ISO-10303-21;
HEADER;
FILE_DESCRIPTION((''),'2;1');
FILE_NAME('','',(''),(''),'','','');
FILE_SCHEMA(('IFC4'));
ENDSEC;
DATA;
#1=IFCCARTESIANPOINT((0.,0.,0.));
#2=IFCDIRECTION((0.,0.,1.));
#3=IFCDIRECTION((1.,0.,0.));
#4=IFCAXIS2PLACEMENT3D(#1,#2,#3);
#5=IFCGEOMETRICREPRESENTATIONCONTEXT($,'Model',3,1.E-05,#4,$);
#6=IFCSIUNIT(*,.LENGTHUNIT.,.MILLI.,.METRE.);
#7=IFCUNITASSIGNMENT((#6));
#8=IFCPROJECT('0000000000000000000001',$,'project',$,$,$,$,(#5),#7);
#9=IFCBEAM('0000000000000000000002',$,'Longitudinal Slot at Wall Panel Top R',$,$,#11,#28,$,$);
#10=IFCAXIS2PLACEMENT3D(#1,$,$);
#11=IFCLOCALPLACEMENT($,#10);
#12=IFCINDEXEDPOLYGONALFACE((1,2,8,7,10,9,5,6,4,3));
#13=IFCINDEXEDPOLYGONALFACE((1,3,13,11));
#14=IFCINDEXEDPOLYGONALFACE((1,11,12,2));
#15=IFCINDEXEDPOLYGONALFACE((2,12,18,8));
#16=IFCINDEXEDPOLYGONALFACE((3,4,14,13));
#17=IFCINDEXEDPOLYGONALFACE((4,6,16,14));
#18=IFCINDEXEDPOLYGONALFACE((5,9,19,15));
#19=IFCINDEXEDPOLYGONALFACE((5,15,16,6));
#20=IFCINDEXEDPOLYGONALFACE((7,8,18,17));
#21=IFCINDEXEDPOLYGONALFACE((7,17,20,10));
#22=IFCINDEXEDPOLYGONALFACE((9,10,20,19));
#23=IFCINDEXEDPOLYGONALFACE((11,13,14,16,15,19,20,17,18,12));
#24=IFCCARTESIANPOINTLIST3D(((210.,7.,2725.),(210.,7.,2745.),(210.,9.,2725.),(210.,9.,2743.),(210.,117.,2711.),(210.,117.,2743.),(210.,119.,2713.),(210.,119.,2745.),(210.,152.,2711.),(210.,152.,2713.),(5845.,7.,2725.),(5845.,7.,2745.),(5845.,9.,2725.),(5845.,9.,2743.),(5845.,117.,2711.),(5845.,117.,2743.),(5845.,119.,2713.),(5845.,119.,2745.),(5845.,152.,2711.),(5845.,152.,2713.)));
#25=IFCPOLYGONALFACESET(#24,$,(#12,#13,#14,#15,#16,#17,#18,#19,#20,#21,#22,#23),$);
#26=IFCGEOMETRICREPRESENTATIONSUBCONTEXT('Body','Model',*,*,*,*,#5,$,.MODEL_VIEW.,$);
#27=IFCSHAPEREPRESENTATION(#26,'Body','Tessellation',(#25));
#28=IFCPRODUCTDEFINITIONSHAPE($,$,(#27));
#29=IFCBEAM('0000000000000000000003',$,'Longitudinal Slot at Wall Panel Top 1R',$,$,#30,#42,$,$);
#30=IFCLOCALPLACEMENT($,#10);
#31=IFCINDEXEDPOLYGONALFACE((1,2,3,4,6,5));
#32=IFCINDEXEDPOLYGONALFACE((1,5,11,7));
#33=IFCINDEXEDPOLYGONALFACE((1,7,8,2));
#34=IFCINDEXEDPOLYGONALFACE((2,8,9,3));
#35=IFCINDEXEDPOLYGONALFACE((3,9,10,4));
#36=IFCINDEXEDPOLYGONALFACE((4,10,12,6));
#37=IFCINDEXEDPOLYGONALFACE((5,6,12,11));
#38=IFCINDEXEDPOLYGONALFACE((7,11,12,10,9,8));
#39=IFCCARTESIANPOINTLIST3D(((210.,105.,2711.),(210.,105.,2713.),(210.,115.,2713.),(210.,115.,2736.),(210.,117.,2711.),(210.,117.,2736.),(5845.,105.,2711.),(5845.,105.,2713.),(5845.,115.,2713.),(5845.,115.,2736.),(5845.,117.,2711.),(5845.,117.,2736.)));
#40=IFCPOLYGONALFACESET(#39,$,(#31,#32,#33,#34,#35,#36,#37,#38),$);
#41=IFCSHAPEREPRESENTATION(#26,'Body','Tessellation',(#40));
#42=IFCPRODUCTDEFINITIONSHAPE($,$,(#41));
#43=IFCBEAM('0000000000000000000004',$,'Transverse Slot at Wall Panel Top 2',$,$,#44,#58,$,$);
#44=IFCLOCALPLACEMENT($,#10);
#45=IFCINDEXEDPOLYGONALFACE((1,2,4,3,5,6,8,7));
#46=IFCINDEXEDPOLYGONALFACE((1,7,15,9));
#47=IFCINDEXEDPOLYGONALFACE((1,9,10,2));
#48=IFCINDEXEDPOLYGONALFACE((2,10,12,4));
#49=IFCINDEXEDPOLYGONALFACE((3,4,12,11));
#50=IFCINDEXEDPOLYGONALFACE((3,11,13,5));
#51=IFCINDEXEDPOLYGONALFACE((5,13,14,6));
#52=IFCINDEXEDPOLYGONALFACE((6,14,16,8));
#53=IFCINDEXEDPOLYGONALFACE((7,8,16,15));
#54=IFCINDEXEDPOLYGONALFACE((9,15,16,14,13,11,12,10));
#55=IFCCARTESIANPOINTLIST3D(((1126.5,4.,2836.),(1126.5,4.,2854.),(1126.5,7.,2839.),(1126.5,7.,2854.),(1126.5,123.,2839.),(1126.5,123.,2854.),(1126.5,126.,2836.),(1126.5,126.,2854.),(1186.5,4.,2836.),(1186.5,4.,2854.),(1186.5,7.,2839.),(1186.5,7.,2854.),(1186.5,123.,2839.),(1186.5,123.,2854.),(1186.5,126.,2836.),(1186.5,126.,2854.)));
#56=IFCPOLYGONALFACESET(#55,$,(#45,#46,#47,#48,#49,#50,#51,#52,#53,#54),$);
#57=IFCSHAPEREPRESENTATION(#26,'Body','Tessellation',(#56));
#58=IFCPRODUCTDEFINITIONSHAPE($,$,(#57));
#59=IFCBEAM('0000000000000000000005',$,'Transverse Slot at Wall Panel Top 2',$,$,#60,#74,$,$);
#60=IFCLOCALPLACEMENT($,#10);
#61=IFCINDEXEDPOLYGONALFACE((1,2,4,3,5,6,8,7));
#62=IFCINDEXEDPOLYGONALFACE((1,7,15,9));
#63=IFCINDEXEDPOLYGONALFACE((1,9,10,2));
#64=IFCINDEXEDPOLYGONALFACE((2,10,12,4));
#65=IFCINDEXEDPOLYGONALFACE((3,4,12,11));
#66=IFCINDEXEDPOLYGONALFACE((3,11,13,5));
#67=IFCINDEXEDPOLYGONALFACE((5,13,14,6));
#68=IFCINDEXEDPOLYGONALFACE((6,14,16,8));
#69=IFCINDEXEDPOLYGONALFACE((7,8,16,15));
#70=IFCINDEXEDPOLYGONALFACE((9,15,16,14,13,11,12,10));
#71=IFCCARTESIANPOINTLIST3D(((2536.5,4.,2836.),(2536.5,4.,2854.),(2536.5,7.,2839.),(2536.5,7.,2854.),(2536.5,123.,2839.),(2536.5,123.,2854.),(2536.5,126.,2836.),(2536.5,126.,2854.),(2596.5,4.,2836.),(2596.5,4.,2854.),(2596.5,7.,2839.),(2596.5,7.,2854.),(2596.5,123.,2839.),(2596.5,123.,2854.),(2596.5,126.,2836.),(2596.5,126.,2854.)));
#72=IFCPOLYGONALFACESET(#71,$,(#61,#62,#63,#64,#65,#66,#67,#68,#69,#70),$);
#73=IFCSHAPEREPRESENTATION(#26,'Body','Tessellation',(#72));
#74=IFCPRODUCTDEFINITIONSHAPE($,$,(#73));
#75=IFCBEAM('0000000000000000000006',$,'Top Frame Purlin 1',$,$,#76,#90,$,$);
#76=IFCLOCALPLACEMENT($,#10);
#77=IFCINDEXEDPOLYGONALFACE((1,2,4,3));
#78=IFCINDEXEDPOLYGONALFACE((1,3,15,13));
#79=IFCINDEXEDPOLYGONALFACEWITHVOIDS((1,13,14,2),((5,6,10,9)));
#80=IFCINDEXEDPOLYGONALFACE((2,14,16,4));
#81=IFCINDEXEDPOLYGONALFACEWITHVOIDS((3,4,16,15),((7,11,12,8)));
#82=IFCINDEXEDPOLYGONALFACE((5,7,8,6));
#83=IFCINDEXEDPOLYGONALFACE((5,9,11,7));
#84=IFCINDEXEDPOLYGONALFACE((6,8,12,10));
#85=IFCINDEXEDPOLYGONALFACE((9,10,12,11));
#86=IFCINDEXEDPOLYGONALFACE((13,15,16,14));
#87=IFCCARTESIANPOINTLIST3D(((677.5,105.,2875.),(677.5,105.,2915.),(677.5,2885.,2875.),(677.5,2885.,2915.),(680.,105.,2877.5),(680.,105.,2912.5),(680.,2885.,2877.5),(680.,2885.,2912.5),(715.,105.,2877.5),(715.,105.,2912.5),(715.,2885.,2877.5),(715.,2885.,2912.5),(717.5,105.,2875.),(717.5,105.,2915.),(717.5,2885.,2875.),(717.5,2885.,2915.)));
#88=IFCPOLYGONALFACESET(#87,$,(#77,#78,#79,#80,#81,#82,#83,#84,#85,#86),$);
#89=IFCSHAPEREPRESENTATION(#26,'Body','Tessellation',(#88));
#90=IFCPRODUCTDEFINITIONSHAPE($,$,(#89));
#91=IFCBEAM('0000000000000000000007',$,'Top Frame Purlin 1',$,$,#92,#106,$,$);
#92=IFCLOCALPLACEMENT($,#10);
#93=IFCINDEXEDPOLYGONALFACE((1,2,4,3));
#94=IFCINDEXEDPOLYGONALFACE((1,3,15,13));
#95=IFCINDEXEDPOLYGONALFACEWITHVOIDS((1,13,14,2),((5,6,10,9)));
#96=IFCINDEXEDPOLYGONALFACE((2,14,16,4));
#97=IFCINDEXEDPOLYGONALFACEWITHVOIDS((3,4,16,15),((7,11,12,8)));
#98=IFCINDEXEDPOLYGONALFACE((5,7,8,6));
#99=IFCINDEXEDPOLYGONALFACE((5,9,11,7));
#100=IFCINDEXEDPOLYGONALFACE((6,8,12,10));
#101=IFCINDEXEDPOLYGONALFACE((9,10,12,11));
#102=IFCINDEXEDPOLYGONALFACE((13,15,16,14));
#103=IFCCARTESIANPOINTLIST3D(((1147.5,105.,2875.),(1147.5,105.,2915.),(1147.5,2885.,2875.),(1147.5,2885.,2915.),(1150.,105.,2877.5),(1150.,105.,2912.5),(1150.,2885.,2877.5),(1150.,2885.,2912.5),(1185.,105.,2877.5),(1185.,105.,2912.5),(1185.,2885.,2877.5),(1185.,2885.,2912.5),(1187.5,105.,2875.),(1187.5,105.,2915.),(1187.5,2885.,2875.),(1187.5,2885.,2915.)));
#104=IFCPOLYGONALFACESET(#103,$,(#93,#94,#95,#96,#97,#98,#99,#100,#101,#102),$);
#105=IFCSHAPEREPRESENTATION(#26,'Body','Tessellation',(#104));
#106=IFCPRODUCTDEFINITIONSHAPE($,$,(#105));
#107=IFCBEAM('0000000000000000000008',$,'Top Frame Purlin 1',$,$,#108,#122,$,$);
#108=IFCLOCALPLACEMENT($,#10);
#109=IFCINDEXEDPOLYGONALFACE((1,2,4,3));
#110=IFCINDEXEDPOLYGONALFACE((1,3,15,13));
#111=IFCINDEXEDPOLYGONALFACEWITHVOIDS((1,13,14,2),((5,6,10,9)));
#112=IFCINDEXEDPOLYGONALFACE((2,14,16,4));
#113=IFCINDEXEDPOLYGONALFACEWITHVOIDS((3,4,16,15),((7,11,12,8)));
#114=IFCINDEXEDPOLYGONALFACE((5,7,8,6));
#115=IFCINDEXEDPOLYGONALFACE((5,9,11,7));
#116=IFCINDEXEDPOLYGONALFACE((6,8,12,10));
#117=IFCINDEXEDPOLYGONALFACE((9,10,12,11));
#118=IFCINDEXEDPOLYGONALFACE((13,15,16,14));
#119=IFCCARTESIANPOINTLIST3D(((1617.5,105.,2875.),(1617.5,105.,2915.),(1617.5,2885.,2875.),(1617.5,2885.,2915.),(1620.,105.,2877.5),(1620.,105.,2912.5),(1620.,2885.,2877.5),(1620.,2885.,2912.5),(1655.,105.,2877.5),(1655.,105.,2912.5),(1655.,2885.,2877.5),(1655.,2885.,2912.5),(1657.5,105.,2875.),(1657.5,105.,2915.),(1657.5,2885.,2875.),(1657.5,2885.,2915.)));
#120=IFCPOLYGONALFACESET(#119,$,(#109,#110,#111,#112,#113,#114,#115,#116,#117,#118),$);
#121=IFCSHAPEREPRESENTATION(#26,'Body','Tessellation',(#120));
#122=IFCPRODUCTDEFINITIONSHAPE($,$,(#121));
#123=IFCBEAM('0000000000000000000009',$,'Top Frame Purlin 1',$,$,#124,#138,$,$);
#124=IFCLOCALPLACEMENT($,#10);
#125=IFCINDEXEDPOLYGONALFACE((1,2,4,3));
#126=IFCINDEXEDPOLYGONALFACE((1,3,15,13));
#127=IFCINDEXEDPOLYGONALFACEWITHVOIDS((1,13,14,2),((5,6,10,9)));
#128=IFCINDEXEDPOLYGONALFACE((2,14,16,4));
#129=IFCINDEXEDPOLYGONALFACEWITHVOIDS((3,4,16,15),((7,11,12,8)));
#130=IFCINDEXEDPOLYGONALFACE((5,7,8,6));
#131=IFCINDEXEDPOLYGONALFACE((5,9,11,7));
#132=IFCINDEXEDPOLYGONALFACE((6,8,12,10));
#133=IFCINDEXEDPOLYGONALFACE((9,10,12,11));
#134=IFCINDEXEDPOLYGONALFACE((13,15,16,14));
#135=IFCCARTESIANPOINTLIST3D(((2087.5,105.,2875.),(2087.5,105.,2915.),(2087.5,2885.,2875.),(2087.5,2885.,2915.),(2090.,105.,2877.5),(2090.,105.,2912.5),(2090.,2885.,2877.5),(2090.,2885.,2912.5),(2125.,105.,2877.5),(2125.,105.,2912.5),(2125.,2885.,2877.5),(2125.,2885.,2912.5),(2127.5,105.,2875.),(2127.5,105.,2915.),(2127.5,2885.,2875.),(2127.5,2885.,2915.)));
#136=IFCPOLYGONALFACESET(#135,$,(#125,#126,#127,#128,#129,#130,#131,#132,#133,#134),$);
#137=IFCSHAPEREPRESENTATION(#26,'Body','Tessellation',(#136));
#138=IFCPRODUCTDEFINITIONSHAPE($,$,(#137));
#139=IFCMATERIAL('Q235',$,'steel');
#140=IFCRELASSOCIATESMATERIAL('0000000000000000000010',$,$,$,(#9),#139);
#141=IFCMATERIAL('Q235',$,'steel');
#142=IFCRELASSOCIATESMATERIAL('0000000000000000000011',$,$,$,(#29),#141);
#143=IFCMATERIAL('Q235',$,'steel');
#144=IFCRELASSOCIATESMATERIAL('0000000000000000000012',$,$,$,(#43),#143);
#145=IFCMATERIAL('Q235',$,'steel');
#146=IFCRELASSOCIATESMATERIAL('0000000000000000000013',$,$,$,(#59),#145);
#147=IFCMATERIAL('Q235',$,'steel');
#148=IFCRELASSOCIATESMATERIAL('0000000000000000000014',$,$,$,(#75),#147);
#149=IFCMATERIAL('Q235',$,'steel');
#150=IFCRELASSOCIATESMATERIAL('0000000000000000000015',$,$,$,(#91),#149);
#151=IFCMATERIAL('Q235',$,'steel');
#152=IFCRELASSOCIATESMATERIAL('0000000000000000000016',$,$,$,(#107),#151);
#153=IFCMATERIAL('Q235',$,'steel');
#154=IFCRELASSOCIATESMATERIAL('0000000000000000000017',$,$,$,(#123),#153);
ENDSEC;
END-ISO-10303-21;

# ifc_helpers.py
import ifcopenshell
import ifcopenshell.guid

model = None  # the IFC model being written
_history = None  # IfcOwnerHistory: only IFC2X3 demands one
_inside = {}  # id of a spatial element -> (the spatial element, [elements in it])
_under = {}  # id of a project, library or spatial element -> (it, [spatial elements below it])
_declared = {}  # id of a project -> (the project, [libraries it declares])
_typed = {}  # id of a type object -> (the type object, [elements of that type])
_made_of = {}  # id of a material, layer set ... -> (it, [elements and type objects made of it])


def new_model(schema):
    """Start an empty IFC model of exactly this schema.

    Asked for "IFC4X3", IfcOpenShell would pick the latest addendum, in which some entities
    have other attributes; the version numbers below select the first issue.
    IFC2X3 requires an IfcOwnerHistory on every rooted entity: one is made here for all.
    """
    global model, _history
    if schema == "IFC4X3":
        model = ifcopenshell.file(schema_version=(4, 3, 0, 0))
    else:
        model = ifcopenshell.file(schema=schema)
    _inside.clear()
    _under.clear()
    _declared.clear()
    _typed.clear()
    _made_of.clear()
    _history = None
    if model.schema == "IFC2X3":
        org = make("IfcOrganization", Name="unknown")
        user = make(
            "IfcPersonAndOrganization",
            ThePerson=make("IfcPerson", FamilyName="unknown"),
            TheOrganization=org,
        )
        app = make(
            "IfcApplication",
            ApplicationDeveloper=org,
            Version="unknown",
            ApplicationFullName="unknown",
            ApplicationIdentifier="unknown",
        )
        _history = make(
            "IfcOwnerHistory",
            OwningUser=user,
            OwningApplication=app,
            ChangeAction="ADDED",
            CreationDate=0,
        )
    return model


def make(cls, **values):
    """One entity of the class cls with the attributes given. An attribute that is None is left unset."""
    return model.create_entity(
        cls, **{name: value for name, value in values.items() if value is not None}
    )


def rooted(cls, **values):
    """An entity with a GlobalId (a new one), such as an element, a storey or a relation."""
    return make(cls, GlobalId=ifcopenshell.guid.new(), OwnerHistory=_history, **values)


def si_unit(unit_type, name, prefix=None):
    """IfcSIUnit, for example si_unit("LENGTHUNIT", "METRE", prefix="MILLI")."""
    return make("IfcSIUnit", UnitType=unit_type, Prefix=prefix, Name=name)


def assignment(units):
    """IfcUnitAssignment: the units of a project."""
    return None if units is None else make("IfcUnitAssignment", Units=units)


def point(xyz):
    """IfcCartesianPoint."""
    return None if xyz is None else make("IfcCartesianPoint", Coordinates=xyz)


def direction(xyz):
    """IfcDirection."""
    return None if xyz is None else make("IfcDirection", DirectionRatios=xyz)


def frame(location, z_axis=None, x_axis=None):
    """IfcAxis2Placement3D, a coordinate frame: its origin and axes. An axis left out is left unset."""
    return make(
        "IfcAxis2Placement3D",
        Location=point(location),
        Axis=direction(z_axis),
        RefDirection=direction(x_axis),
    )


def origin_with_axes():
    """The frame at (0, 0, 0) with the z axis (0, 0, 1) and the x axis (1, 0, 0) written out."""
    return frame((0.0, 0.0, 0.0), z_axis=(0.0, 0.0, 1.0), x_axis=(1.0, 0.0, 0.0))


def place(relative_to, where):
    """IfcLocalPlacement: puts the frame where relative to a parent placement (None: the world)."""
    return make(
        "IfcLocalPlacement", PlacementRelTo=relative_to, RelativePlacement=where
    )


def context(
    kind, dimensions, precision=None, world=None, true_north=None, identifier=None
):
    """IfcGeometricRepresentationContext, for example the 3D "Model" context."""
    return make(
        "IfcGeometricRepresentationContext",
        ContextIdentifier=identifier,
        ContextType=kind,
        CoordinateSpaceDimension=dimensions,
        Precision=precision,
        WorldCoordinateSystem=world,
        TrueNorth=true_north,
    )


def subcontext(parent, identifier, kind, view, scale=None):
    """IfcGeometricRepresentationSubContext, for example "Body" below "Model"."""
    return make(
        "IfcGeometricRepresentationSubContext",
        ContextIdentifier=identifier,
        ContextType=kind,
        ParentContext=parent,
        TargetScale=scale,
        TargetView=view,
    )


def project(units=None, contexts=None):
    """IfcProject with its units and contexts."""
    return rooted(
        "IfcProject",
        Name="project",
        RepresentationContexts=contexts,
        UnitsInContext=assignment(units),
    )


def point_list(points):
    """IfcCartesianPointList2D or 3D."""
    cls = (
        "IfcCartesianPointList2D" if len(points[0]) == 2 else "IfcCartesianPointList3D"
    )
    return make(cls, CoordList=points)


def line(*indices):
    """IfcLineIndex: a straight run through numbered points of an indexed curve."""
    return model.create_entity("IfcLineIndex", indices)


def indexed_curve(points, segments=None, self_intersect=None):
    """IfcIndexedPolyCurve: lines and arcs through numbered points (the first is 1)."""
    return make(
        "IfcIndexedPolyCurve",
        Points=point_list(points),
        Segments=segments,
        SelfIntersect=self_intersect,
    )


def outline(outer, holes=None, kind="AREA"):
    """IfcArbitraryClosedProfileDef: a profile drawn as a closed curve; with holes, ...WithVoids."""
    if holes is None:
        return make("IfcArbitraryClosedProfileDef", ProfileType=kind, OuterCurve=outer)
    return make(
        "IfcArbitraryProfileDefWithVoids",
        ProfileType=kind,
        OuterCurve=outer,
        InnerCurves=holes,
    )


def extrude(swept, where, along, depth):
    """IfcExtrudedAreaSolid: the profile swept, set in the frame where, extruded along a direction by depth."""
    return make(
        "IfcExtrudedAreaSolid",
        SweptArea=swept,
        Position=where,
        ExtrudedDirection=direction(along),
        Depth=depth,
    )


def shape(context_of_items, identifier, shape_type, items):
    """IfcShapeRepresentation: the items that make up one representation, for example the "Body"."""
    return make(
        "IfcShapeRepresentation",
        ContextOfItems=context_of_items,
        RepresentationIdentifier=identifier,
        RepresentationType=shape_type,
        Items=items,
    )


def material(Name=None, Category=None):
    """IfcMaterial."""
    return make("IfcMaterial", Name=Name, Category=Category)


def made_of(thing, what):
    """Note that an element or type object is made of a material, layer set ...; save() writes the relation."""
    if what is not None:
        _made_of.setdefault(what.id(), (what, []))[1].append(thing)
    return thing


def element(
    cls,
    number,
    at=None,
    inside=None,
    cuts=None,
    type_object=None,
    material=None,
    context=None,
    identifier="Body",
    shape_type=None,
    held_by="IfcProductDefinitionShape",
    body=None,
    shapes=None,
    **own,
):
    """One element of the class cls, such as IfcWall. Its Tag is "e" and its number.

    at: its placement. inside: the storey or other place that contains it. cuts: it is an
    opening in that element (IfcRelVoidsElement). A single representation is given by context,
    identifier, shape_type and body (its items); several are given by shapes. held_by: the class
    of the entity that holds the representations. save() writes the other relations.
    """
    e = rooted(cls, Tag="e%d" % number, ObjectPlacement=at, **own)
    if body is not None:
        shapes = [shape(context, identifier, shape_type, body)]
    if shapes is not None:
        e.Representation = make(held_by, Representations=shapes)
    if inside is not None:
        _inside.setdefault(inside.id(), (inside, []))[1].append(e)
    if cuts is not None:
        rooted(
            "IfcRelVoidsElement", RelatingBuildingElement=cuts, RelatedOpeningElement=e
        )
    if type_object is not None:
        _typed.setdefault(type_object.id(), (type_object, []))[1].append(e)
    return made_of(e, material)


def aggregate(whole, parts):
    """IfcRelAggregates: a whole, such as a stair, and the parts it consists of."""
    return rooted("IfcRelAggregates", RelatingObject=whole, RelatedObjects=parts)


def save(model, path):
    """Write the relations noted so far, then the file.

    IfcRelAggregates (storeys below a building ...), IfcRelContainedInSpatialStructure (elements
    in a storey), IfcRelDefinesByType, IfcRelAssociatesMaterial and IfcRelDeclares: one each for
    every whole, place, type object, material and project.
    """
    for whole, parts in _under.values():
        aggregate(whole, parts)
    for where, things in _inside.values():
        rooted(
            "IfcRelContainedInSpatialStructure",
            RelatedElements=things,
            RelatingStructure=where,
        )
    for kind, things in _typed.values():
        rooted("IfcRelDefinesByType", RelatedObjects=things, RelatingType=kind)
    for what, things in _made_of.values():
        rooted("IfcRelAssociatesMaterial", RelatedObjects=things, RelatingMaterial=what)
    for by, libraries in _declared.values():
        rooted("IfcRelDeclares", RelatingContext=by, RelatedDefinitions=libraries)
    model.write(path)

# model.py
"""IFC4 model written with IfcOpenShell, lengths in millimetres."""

from ifc_helpers import new_model, si_unit, frame, origin_with_axes, place, context, subcontext, project, line, indexed_curve, outline, extrude, material, element, save


model = new_model("IFC4")

# Units and contexts
model_context = context("Model", 3, precision=1e-05, world=origin_with_axes())
body_context = subcontext(model_context, "Body", "Model", "MODEL_VIEW")
ifc_project = project(units=[si_unit("LENGTHUNIT", "METRE", prefix="MILLI")], contexts=[model_context])

# Beams
ifc_material_1 = material(Name="Q235", Category="steel")
beam_1_placement = place(None, frame((210.0, 0.0, 2711.0), z_axis=(1.0, 0.0, 0.0), x_axis=(0.0, 1.0, 0.0)))
element("IfcBeam", 1, at=beam_1_placement, material=ifc_material_1, Name="Longitudinal Slot at Wall Panel Top R", context=body_context, shape_type="SweptSolid", body=[
    extrude(outline(indexed_curve([(152.0, 0.0), (117.0, 0.0), (117.0, 32.0), (9.0, 32.0), (9.0, 14.0), (7.0, 14.0), (7.0, 34.0), (119.0, 34.0), (119.0, 2.0), (152.0, 2.0), (152.0, 0.0)], segments=[line(1, 2, 3, 4, 5, 6, 7, 8, 9, 10, 11, 1)])), origin_with_axes(), (0.0, 0.0, 1.0), 5635.0),
])
ifc_material_2 = material(Name="Q235", Category="steel")
beam_2_placement = place(None, frame((210.0, 0.0, 2711.0), z_axis=(1.0, 0.0, 0.0), x_axis=(0.0, 1.0, 0.0)))
element("IfcBeam", 2, at=beam_2_placement, material=ifc_material_2, Name="Longitudinal Slot at Wall Panel Top 1R", context=body_context, shape_type="SweptSolid", body=[
    extrude(outline(indexed_curve([(117.0, 0.0), (105.0, 0.0), (105.0, 2.0), (115.0, 2.0), (115.0, 25.0), (117.0, 25.0), (117.0, 0.0)], segments=[line(1, 2, 3, 4, 5, 6, 7, 1)])), origin_with_axes(), (0.0, 0.0, 1.0), 5635.0),
])
ifc_material_3 = material(Name="Q235", Category="steel")
beam_3_placement = place(None, frame((1126.5, 4.0, 2836.0), z_axis=(1.0, 0.0, 0.0), x_axis=(0.0, 0.0, -1.0)))
element("IfcBeam", 3, at=beam_3_placement, material=ifc_material_3, Name="Transverse Slot at Wall Panel Top 2", context=body_context, shape_type="SweptSolid", body=[
    extrude(outline(indexed_curve([(0.0, 0.0), (0.0, 122.0), (-18.0, 122.0), (-18.0, 119.0), (-3.0, 119.0), (-3.0, 3.0), (-18.0, 3.0), (-18.0, 0.0), (0.0, 0.0)], segments=[line(1, 2, 3, 4, 5, 6, 7, 8, 9, 1)])), origin_with_axes(), (0.0, 0.0, 1.0), 60.0),
])
ifc_material_4 = material(Name="Q235", Category="steel")
beam_4_placement = place(None, frame((2536.5, 4.0, 2836.0), z_axis=(1.0, 0.0, 0.0), x_axis=(0.0, 0.0, -1.0)))
element("IfcBeam", 4, at=beam_4_placement, material=ifc_material_4, Name="Transverse Slot at Wall Panel Top 2", context=body_context, shape_type="SweptSolid", body=[
    extrude(outline(indexed_curve([(0.0, 0.0), (0.0, 122.0), (-18.0, 122.0), (-18.0, 119.0), (-3.0, 119.0), (-3.0, 3.0), (-18.0, 3.0), (-18.0, 0.0), (0.0, 0.0)], segments=[line(1, 2, 3, 4, 5, 6, 7, 8, 9, 1)])), origin_with_axes(), (0.0, 0.0, 1.0), 60.0),
])

# Beams, openings
ifc_material_5 = material(Name="Q235", Category="steel")
beam_5_placement = place(None, frame((677.5, 105.0, 2875.0), z_axis=(0.0, 1.0, 0.0), x_axis=(1.0, 0.0, 0.0)))
beam_5 = element("IfcBeam", 5, at=beam_5_placement, material=ifc_material_5, Name="Top Frame Purlin 1", context=body_context, shape_type="SweptSolid", body=[
    extrude(outline(indexed_curve([(0.0, 0.0), (0.0, -40.0), (40.0, -40.0), (40.0, 0.0), (0.0, 0.0)], segments=[line(1, 2, 3, 4, 5, 1)])), origin_with_axes(), (0.0, 0.0, 1.0), 2780.0),
])
opening_1_placement = place(beam_5_placement, frame((2.5, -2.5, 0.0), z_axis=(0.0, 0.0, 1.0), x_axis=(1.0, 0.0, 0.0)))
element("IfcOpeningElement", 6, at=opening_1_placement, cuts=beam_5, context=body_context, shape_type="SweptSolid", body=[
    extrude(outline(indexed_curve([(0.0, 0.0), (0.0, -35.0), (35.0, -35.0), (35.0, 0.0)], segments=[line(1, 2, 3, 4, 1)])), origin_with_axes(), (0.0, 0.0, 1.0), 2780.0),
])
ifc_material_6 = material(Name="Q235", Category="steel")
beam_6_placement = place(None, frame((1147.5, 105.0, 2875.0), z_axis=(0.0, 1.0, 0.0), x_axis=(1.0, 0.0, 0.0)))
beam_6 = element("IfcBeam", 7, at=beam_6_placement, material=ifc_material_6, Name="Top Frame Purlin 1", context=body_context, shape_type="SweptSolid", body=[
    extrude(outline(indexed_curve([(0.0, 0.0), (0.0, -40.0), (40.0, -40.0), (40.0, 0.0), (0.0, 0.0)], segments=[line(1, 2, 3, 4, 5, 1)])), origin_with_axes(), (0.0, 0.0, 1.0), 2780.0),
])
opening_2_placement = place(beam_6_placement, frame((2.5, -2.5, 0.0), z_axis=(0.0, 0.0, 1.0), x_axis=(1.0, 0.0, 0.0)))
element("IfcOpeningElement", 8, at=opening_2_placement, cuts=beam_6, context=body_context, shape_type="SweptSolid", body=[
    extrude(outline(indexed_curve([(0.0, 0.0), (0.0, -35.0), (35.0, -35.0), (35.0, 0.0)], segments=[line(1, 2, 3, 4, 1)])), origin_with_axes(), (0.0, 0.0, 1.0), 2780.0),
])
ifc_material_7 = material(Name="Q235", Category="steel")
beam_7_placement = place(None, frame((1617.5, 105.0, 2875.0), z_axis=(0.0, 1.0, 0.0), x_axis=(1.0, 0.0, 0.0)))
beam_7 = element("IfcBeam", 9, at=beam_7_placement, material=ifc_material_7, Name="Top Frame Purlin 1", context=body_context, shape_type="SweptSolid", body=[
    extrude(outline(indexed_curve([(0.0, 0.0), (0.0, -40.0), (40.0, -40.0), (40.0, 0.0), (0.0, 0.0)], segments=[line(1, 2, 3, 4, 5, 1)])), origin_with_axes(), (0.0, 0.0, 1.0), 2780.0),
])
opening_3_placement = place(beam_7_placement, frame((2.5, -2.5, 0.0), z_axis=(0.0, 0.0, 1.0), x_axis=(1.0, 0.0, 0.0)))
element("IfcOpeningElement", 10, at=opening_3_placement, cuts=beam_7, context=body_context, shape_type="SweptSolid", body=[
    extrude(outline(indexed_curve([(0.0, 0.0), (0.0, -35.0), (35.0, -35.0), (35.0, 0.0)], segments=[line(1, 2, 3, 4, 1)])), origin_with_axes(), (0.0, 0.0, 1.0), 2780.0),
])
ifc_material_8 = material(Name="Q235", Category="steel")
beam_8_placement = place(None, frame((2087.5, 105.0, 2875.0), z_axis=(0.0, 1.0, 0.0), x_axis=(1.0, 0.0, 0.0)))
beam_8 = element("IfcBeam", 11, at=beam_8_placement, material=ifc_material_8, Name="Top Frame Purlin 1", context=body_context, shape_type="SweptSolid", body=[
    extrude(outline(indexed_curve([(0.0, 0.0), (0.0, -40.0), (40.0, -40.0), (40.0, 0.0), (0.0, 0.0)], segments=[line(1, 2, 3, 4, 5, 1)])), origin_with_axes(), (0.0, 0.0, 1.0), 2780.0),
])
opening_4_placement = place(beam_8_placement, frame((2.5, -2.5, 0.0), z_axis=(0.0, 0.0, 1.0), x_axis=(1.0, 0.0, 0.0)))
element("IfcOpeningElement", 12, at=opening_4_placement, cuts=beam_8, context=body_context, shape_type="SweptSolid", body=[
    extrude(outline(indexed_curve([(0.0, 0.0), (0.0, -35.0), (35.0, -35.0), (35.0, 0.0)], segments=[line(1, 2, 3, 4, 1)])), origin_with_axes(), (0.0, 0.0, 1.0), 2780.0),
])

save(model, "model.ifc")
